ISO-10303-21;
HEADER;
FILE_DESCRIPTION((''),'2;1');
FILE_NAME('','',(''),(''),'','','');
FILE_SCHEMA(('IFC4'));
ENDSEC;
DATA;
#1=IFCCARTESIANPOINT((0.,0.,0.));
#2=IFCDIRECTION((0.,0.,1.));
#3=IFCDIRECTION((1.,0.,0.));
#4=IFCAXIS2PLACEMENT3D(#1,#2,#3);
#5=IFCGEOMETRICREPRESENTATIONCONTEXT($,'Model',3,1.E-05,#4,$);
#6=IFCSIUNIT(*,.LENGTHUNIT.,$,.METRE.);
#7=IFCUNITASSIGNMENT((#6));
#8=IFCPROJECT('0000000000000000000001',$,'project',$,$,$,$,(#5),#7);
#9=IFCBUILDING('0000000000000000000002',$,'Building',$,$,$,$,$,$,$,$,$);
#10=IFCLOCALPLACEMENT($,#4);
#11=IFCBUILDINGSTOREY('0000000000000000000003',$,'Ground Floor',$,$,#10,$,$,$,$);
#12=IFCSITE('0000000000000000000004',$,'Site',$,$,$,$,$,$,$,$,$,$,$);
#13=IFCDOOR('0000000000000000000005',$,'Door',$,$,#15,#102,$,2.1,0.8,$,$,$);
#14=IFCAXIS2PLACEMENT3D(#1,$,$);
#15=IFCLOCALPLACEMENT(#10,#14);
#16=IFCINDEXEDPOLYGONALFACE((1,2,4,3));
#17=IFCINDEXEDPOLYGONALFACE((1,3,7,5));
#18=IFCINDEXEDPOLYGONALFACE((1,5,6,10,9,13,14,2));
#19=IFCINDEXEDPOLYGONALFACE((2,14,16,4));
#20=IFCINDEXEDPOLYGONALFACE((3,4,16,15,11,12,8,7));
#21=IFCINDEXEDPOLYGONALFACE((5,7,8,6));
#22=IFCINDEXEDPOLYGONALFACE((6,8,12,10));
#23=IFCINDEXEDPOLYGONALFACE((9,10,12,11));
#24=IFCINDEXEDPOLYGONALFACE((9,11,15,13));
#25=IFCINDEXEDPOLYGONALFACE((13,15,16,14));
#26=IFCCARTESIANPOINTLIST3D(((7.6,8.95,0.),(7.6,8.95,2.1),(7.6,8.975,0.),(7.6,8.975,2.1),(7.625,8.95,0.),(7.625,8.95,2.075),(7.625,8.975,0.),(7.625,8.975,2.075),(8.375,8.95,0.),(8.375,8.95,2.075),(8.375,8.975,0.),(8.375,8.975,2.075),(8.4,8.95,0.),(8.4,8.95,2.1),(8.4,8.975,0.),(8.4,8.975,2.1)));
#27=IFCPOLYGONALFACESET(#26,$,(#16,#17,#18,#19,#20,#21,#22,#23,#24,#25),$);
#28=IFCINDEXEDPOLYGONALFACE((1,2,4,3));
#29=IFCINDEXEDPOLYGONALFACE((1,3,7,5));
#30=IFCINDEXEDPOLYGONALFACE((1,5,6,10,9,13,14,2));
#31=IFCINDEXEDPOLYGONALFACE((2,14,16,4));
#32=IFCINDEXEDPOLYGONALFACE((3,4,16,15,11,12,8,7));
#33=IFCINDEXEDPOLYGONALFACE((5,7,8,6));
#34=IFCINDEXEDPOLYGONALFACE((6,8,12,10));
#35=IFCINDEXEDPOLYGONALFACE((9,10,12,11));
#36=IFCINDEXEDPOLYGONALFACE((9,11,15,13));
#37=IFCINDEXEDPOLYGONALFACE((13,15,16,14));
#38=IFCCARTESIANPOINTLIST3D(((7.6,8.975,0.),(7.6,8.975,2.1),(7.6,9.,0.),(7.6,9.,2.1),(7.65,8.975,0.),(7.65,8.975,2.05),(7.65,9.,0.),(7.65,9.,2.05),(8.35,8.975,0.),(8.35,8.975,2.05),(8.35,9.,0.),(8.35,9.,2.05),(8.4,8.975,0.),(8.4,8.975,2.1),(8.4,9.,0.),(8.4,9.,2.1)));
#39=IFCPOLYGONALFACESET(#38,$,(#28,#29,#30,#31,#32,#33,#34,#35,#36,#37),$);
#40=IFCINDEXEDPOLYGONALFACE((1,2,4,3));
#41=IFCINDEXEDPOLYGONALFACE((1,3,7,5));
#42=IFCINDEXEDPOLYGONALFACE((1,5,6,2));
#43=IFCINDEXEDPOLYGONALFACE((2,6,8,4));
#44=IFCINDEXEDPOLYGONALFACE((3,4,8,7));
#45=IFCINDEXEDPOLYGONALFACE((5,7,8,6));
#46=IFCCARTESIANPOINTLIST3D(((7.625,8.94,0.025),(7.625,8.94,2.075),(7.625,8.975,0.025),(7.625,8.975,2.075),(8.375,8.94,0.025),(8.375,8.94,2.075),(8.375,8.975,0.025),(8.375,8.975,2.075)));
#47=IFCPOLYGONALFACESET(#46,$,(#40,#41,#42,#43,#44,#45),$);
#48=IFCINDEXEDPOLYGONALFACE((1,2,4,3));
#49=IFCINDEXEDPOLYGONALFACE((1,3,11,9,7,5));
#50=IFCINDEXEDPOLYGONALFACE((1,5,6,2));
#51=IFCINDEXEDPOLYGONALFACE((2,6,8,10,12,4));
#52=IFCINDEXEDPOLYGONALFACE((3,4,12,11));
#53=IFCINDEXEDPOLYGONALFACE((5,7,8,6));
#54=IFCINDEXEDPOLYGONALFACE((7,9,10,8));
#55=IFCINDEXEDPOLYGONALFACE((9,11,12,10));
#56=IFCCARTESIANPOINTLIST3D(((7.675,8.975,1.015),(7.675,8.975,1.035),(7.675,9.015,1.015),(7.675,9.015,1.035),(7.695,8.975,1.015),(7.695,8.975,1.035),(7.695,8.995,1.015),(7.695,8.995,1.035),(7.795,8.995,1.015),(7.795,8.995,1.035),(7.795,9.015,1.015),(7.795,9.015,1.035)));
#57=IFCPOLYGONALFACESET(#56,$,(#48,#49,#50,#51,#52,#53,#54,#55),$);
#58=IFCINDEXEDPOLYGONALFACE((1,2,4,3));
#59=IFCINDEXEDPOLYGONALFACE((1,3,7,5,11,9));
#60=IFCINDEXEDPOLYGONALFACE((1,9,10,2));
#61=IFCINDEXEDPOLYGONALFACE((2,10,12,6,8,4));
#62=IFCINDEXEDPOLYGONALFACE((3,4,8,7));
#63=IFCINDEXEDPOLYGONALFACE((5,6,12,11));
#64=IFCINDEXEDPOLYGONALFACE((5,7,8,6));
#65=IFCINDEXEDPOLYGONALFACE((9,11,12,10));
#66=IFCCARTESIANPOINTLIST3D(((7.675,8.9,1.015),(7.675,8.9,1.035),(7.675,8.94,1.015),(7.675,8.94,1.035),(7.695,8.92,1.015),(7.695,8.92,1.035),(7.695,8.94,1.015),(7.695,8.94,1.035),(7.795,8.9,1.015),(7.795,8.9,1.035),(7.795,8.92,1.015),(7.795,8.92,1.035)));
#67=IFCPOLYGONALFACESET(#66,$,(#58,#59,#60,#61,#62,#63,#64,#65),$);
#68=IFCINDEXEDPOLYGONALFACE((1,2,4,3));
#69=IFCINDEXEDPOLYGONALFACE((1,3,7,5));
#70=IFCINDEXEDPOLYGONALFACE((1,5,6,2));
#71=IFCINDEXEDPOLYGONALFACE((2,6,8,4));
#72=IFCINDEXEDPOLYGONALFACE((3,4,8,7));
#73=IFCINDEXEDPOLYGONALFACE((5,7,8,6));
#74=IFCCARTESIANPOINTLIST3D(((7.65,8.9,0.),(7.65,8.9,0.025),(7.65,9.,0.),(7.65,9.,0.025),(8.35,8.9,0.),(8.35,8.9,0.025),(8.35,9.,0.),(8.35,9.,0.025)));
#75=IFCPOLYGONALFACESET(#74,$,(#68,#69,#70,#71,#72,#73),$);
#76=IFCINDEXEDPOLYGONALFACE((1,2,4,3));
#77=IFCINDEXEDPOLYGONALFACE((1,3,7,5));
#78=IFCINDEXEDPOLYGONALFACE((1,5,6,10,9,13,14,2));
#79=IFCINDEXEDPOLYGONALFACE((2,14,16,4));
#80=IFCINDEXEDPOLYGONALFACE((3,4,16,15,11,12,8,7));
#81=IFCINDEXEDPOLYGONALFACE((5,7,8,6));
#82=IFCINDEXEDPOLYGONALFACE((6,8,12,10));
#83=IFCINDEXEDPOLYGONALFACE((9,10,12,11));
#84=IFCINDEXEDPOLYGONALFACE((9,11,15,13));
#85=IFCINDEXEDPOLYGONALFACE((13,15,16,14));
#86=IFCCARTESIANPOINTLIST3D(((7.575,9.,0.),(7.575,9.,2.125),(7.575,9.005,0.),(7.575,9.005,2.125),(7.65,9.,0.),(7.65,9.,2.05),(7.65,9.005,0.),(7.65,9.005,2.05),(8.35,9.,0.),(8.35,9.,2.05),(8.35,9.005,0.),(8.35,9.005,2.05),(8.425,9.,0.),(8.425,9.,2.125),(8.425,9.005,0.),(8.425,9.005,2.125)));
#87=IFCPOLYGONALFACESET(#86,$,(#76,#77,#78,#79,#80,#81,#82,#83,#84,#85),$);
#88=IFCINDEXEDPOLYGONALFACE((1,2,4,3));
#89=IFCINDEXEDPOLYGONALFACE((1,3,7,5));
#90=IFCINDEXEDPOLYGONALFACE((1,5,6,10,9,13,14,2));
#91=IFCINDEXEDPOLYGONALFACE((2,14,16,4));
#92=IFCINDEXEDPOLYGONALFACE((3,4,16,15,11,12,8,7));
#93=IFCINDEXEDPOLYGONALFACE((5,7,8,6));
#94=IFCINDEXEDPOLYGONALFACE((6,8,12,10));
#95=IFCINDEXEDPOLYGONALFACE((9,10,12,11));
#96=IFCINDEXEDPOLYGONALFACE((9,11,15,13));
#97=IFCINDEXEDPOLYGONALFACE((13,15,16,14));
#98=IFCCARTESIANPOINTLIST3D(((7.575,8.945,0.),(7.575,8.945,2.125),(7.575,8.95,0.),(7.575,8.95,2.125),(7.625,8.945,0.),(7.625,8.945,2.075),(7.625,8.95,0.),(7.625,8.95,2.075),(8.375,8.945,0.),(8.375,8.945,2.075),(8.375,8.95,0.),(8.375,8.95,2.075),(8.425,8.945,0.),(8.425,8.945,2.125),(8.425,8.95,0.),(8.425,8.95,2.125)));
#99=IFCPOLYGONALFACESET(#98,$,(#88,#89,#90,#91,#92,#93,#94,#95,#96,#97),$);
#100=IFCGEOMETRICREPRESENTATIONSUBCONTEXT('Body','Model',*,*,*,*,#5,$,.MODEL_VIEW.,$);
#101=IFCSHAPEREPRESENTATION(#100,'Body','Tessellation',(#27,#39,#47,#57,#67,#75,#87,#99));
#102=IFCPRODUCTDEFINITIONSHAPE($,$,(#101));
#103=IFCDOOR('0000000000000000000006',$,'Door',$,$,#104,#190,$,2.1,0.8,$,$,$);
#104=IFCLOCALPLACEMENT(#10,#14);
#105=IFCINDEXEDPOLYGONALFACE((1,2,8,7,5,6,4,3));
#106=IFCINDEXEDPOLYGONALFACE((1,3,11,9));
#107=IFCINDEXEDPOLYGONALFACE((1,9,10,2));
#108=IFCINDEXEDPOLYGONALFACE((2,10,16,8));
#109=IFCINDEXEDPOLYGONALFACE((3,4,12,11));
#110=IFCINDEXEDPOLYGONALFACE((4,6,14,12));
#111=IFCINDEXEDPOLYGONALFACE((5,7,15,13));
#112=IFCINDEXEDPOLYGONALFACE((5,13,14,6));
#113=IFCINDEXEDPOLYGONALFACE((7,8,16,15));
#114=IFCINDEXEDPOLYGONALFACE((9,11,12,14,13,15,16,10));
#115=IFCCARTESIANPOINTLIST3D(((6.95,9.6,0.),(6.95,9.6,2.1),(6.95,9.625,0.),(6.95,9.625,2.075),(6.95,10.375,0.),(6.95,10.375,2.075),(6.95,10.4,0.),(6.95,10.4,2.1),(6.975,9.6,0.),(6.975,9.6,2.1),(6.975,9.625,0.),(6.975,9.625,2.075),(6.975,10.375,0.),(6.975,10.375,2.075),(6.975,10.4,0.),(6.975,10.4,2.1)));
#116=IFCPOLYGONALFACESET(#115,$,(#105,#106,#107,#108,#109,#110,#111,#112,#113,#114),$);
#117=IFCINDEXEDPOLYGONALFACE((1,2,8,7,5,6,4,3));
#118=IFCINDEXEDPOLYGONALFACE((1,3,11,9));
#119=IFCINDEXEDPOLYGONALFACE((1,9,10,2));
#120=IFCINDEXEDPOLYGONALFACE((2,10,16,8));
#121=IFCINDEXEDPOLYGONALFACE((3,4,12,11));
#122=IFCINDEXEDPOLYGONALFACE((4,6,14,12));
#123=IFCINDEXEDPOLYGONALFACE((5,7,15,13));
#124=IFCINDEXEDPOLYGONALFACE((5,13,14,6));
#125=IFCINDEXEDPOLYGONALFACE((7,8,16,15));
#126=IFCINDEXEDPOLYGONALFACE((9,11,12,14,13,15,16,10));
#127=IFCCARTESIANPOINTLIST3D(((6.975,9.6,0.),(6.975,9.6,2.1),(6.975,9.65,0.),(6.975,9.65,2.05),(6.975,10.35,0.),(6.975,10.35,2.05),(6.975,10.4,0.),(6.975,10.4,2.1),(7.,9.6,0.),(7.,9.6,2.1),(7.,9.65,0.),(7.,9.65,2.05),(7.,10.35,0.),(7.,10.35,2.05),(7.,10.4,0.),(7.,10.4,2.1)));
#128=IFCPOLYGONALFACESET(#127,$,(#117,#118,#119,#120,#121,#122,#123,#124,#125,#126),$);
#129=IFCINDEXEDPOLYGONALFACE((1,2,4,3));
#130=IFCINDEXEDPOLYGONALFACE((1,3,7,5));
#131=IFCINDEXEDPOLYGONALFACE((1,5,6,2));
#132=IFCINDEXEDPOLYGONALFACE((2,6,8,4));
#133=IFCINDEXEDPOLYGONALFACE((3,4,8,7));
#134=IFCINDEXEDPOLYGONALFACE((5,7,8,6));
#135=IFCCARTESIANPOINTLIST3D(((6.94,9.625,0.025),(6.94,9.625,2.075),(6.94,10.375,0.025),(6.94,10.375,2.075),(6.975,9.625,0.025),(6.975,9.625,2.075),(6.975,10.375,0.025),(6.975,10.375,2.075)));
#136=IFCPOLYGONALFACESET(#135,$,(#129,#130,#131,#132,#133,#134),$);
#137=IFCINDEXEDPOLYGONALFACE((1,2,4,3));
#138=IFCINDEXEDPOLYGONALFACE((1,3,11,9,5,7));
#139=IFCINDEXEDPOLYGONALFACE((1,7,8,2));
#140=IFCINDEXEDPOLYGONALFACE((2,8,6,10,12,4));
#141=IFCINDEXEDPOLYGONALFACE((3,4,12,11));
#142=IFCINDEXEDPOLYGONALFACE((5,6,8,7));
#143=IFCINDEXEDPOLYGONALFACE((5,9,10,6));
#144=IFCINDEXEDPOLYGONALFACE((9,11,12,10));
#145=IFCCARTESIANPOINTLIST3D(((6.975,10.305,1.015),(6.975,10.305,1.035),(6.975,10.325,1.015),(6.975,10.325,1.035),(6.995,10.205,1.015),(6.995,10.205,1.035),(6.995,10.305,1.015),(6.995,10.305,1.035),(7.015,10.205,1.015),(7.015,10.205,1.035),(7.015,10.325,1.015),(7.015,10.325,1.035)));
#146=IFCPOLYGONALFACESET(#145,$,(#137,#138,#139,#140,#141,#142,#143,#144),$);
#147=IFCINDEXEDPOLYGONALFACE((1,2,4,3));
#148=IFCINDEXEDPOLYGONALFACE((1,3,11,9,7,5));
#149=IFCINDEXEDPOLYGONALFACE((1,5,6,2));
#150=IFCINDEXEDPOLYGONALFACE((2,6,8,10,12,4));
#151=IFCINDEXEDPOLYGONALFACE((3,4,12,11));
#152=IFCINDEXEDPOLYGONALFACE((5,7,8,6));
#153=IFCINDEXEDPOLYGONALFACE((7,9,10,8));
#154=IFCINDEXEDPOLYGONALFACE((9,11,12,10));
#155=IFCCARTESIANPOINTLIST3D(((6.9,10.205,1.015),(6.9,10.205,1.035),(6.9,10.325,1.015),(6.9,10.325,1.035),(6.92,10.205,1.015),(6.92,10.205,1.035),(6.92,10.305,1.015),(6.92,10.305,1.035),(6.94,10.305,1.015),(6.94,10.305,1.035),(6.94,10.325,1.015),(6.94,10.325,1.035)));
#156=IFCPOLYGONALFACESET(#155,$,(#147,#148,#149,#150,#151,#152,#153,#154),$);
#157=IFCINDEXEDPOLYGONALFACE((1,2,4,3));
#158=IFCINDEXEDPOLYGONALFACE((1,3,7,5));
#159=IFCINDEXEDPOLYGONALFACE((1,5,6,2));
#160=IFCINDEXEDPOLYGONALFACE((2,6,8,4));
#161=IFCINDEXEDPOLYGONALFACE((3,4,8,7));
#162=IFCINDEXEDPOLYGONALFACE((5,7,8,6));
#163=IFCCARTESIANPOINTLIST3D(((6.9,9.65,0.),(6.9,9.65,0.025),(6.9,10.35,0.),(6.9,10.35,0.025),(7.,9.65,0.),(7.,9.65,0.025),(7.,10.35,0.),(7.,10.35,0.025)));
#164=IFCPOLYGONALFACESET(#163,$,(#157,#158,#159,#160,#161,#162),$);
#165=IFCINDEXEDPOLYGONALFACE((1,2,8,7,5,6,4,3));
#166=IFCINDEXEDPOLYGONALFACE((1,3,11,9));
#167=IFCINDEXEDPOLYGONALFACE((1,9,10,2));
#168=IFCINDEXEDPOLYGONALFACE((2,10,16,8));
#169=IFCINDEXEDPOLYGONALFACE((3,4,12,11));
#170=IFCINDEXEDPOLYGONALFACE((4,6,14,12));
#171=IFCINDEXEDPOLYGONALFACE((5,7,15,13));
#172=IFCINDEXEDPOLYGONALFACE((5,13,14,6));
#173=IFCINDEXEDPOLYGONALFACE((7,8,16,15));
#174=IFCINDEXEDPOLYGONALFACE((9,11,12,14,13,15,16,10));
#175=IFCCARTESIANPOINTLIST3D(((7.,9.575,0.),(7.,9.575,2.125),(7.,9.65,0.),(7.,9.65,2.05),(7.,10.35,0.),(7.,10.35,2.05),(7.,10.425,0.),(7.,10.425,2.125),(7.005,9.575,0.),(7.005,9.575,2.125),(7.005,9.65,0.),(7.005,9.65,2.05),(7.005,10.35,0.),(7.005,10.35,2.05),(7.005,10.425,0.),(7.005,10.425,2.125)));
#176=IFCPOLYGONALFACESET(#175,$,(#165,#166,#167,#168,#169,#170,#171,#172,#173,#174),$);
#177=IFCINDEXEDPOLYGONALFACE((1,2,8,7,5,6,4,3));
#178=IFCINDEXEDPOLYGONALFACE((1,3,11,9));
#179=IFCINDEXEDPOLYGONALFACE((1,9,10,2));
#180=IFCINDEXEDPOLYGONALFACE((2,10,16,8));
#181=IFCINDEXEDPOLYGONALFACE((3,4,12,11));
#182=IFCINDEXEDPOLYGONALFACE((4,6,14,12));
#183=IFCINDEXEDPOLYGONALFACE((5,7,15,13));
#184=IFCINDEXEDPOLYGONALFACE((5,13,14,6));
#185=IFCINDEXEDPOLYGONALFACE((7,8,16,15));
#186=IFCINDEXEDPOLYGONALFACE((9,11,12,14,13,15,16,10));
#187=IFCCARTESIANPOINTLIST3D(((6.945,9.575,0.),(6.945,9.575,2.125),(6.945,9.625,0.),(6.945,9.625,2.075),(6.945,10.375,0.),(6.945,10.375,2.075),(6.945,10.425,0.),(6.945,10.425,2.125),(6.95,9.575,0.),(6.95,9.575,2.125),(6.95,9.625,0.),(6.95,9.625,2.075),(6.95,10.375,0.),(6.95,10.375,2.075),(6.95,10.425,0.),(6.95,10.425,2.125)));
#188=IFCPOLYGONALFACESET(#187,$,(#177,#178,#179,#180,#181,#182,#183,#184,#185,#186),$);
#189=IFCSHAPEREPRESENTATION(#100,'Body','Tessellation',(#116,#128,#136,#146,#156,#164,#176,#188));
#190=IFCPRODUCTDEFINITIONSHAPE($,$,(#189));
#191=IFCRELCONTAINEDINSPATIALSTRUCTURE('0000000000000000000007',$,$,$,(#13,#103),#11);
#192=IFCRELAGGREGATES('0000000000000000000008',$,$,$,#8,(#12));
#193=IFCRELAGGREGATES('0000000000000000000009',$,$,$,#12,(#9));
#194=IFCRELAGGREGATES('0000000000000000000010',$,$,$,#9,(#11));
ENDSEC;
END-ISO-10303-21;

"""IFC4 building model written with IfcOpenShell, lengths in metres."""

from ifc_helpers import new_model, si_unit, frame, origin_with_axes, place, context, subcontext, project, spatial, line, indexed_curve, outline, extrude, element, save


model = new_model("IFC4")

# Units and contexts
model_context = context("Model", 3, precision=1e-05, world=origin_with_axes())
body_context = subcontext(model_context, "Body", "Model", "MODEL_VIEW")
ifc_project = project(units=[si_unit("LENGTHUNIT", "METRE")], contexts=[model_context])

# Site, building, storey
site = spatial("IfcSite", under=ifc_project, Name="Site")
building = spatial("IfcBuilding", under=site, Name="Building")
storey_placement = place(None, origin_with_axes())
storey = spatial("IfcBuildingStorey", under=building, at=storey_placement, Name="Ground Floor")

# Doors
door_1_placement = place(storey_placement, frame((8.4, 9.0, 0.0), z_axis=(0.0, 0.0, 1.0), x_axis=(-1.0, 0.0, 0.0)))
element("IfcDoor", 1, at=door_1_placement, inside=storey, Name="Door", OverallHeight=2.1, OverallWidth=0.8, context=body_context, shape_type="SweptSolid", body=[
    extrude(outline(indexed_curve([(0.0, 0.0), (0.0, 2.1), (0.8, 2.1), (0.8, 0.0), (0.775, 0.0), (0.775, 2.075), (0.025, 2.075), (0.025, 0.0)], segments=[line(1, 2, 3, 4, 5, 6, 7, 8, 1)])), frame((0.0, 0.025, 0.0), z_axis=(0.0, -1.0, 0.0), x_axis=(1.0, 0.0, 0.0)), (0.0, 0.0, -1.0), 0.025),
    extrude(outline(indexed_curve([(0.0, 0.0), (0.0, 2.1), (0.8, 2.1), (0.8, 0.0), (0.75, 0.0), (0.75, 2.05), (0.05, 2.05), (0.05, 0.0)], segments=[line(1, 2, 3, 4, 5, 6, 7, 8, 1)])), frame((0.0, 0.0, 0.0), z_axis=(0.0, -1.0, 0.0), x_axis=(1.0, 0.0, 0.0)), (0.0, 0.0, -1.0), 0.025),
    extrude(outline(indexed_curve([(0.0, 0.0), (0.75, 0.0), (0.75, 0.035), (0.0, 0.035)], segments=[line(1, 2, 3, 4, 1)])), frame((0.025, 0.025, 0.025), z_axis=(0.0, 0.0, 1.0), x_axis=(1.0, 0.0, 0.0)), (0.0, 0.0, 1.0), 2.05),
    extrude(outline(indexed_curve([(0.0, 0.0), (0.0, -0.04), (-0.12, -0.04), (-0.12, -0.02), (-0.02, -0.02), (-0.02, 0.0)], segments=[line(1, 2, 3, 4, 5, 6, 1)])), frame((0.725, 0.025, 1.015), z_axis=(0.0, 0.0, 1.0), x_axis=(1.0, 0.0, 0.0)), (0.0, 0.0, 1.0), 0.02),
    extrude(outline(indexed_curve([(0.0, 0.0), (0.0, 0.04), (-0.12, 0.04), (-0.12, 0.02), (-0.02, 0.02), (-0.02, 0.0)], segments=[line(1, 2, 3, 4, 5, 6, 1)])), frame((0.725, 0.06, 1.015), z_axis=(0.0, 0.0, 1.0), x_axis=(1.0, 0.0, 0.0)), (0.0, 0.0, 1.0), 0.02),
    extrude(outline(indexed_curve([(0.0, 0.0), (0.7, 0.0), (0.7, 0.1), (0.0, 0.1)], segments=[line(1, 2, 3, 4, 1)])), frame((0.05, 0.0, 0.0), z_axis=(0.0, 0.0, 1.0), x_axis=(1.0, 0.0, 0.0)), (0.0, 0.0, 1.0), 0.025),
    extrude(outline(indexed_curve([(0.0, 0.0), (0.0, 2.125), (0.85, 2.125), (0.85, 0.0), (0.775, 0.0), (0.775, 2.05), (0.075, 2.05), (0.075, 0.0)], segments=[line(1, 2, 3, 4, 5, 6, 7, 8, 1)])), frame((-0.025, -0.005, 0.0), z_axis=(0.0, -1.0, 0.0), x_axis=(1.0, 0.0, 0.0)), (0.0, 0.0, -1.0), 0.005),
    extrude(outline(indexed_curve([(0.0, 0.0), (0.0, 2.125), (0.85, 2.125), (0.85, 0.0), (0.8, 0.0), (0.8, 2.075), (0.05, 2.075), (0.05, 0.0)], segments=[line(1, 2, 3, 4, 5, 6, 7, 8, 1)])), frame((-0.025, 0.05, 0.0), z_axis=(0.0, -1.0, 0.0), x_axis=(1.0, 0.0, 0.0)), (0.0, 0.0, -1.0), 0.005),
])
door_2_placement = place(storey_placement, frame((7.0, 9.6, 0.0), z_axis=(0.0, 0.0, 1.0), x_axis=(0.0, 1.0, 0.0)))
element("IfcDoor", 2, at=door_2_placement, inside=storey, Name="Door", OverallHeight=2.1, OverallWidth=0.8, context=body_context, shape_type="SweptSolid", body=[
    extrude(outline(indexed_curve([(0.0, 0.0), (0.0, 2.1), (0.8, 2.1), (0.8, 0.0), (0.775, 0.0), (0.775, 2.075), (0.025, 2.075), (0.025, 0.0)], segments=[line(1, 2, 3, 4, 5, 6, 7, 8, 1)])), frame((0.0, 0.025, 0.0), z_axis=(0.0, -1.0, 0.0), x_axis=(1.0, 0.0, 0.0)), (0.0, 0.0, -1.0), 0.025),
    extrude(outline(indexed_curve([(0.0, 0.0), (0.0, 2.1), (0.8, 2.1), (0.8, 0.0), (0.75, 0.0), (0.75, 2.05), (0.05, 2.05), (0.05, 0.0)], segments=[line(1, 2, 3, 4, 5, 6, 7, 8, 1)])), frame((0.0, 0.0, 0.0), z_axis=(0.0, -1.0, 0.0), x_axis=(1.0, 0.0, 0.0)), (0.0, 0.0, -1.0), 0.025),
    extrude(outline(indexed_curve([(0.0, 0.0), (0.75, 0.0), (0.75, 0.035), (0.0, 0.035)], segments=[line(1, 2, 3, 4, 1)])), frame((0.025, 0.025, 0.025), z_axis=(0.0, 0.0, 1.0), x_axis=(1.0, 0.0, 0.0)), (0.0, 0.0, 1.0), 2.05),
    extrude(outline(indexed_curve([(0.0, 0.0), (0.0, -0.04), (-0.12, -0.04), (-0.12, -0.02), (-0.02, -0.02), (-0.02, 0.0)], segments=[line(1, 2, 3, 4, 5, 6, 1)])), frame((0.725, 0.025, 1.015), z_axis=(0.0, 0.0, 1.0), x_axis=(1.0, 0.0, 0.0)), (0.0, 0.0, 1.0), 0.02),
    extrude(outline(indexed_curve([(0.0, 0.0), (0.0, 0.04), (-0.12, 0.04), (-0.12, 0.02), (-0.02, 0.02), (-0.02, 0.0)], segments=[line(1, 2, 3, 4, 5, 6, 1)])), frame((0.725, 0.06, 1.015), z_axis=(0.0, 0.0, 1.0), x_axis=(1.0, 0.0, 0.0)), (0.0, 0.0, 1.0), 0.02),
    extrude(outline(indexed_curve([(0.0, 0.0), (0.7, 0.0), (0.7, 0.1), (0.0, 0.1)], segments=[line(1, 2, 3, 4, 1)])), frame((0.05, 0.0, 0.0), z_axis=(0.0, 0.0, 1.0), x_axis=(1.0, 0.0, 0.0)), (0.0, 0.0, 1.0), 0.025),
    extrude(outline(indexed_curve([(0.0, 0.0), (0.0, 2.125), (0.85, 2.125), (0.85, 0.0), (0.775, 0.0), (0.775, 2.05), (0.075, 2.05), (0.075, 0.0)], segments=[line(1, 2, 3, 4, 5, 6, 7, 8, 1)])), frame((-0.025, -0.005, 0.0), z_axis=(0.0, -1.0, 0.0), x_axis=(1.0, 0.0, 0.0)), (0.0, 0.0, -1.0), 0.005),
    extrude(outline(indexed_curve([(0.0, 0.0), (0.0, 2.125), (0.85, 2.125), (0.85, 0.0), (0.8, 0.0), (0.8, 2.075), (0.05, 2.075), (0.05, 0.0)], segments=[line(1, 2, 3, 4, 5, 6, 7, 8, 1)])), frame((-0.025, 0.05, 0.0), z_axis=(0.0, -1.0, 0.0), x_axis=(1.0, 0.0, 0.0)), (0.0, 0.0, -1.0), 0.005),
])

save(model, "model.ifc")
